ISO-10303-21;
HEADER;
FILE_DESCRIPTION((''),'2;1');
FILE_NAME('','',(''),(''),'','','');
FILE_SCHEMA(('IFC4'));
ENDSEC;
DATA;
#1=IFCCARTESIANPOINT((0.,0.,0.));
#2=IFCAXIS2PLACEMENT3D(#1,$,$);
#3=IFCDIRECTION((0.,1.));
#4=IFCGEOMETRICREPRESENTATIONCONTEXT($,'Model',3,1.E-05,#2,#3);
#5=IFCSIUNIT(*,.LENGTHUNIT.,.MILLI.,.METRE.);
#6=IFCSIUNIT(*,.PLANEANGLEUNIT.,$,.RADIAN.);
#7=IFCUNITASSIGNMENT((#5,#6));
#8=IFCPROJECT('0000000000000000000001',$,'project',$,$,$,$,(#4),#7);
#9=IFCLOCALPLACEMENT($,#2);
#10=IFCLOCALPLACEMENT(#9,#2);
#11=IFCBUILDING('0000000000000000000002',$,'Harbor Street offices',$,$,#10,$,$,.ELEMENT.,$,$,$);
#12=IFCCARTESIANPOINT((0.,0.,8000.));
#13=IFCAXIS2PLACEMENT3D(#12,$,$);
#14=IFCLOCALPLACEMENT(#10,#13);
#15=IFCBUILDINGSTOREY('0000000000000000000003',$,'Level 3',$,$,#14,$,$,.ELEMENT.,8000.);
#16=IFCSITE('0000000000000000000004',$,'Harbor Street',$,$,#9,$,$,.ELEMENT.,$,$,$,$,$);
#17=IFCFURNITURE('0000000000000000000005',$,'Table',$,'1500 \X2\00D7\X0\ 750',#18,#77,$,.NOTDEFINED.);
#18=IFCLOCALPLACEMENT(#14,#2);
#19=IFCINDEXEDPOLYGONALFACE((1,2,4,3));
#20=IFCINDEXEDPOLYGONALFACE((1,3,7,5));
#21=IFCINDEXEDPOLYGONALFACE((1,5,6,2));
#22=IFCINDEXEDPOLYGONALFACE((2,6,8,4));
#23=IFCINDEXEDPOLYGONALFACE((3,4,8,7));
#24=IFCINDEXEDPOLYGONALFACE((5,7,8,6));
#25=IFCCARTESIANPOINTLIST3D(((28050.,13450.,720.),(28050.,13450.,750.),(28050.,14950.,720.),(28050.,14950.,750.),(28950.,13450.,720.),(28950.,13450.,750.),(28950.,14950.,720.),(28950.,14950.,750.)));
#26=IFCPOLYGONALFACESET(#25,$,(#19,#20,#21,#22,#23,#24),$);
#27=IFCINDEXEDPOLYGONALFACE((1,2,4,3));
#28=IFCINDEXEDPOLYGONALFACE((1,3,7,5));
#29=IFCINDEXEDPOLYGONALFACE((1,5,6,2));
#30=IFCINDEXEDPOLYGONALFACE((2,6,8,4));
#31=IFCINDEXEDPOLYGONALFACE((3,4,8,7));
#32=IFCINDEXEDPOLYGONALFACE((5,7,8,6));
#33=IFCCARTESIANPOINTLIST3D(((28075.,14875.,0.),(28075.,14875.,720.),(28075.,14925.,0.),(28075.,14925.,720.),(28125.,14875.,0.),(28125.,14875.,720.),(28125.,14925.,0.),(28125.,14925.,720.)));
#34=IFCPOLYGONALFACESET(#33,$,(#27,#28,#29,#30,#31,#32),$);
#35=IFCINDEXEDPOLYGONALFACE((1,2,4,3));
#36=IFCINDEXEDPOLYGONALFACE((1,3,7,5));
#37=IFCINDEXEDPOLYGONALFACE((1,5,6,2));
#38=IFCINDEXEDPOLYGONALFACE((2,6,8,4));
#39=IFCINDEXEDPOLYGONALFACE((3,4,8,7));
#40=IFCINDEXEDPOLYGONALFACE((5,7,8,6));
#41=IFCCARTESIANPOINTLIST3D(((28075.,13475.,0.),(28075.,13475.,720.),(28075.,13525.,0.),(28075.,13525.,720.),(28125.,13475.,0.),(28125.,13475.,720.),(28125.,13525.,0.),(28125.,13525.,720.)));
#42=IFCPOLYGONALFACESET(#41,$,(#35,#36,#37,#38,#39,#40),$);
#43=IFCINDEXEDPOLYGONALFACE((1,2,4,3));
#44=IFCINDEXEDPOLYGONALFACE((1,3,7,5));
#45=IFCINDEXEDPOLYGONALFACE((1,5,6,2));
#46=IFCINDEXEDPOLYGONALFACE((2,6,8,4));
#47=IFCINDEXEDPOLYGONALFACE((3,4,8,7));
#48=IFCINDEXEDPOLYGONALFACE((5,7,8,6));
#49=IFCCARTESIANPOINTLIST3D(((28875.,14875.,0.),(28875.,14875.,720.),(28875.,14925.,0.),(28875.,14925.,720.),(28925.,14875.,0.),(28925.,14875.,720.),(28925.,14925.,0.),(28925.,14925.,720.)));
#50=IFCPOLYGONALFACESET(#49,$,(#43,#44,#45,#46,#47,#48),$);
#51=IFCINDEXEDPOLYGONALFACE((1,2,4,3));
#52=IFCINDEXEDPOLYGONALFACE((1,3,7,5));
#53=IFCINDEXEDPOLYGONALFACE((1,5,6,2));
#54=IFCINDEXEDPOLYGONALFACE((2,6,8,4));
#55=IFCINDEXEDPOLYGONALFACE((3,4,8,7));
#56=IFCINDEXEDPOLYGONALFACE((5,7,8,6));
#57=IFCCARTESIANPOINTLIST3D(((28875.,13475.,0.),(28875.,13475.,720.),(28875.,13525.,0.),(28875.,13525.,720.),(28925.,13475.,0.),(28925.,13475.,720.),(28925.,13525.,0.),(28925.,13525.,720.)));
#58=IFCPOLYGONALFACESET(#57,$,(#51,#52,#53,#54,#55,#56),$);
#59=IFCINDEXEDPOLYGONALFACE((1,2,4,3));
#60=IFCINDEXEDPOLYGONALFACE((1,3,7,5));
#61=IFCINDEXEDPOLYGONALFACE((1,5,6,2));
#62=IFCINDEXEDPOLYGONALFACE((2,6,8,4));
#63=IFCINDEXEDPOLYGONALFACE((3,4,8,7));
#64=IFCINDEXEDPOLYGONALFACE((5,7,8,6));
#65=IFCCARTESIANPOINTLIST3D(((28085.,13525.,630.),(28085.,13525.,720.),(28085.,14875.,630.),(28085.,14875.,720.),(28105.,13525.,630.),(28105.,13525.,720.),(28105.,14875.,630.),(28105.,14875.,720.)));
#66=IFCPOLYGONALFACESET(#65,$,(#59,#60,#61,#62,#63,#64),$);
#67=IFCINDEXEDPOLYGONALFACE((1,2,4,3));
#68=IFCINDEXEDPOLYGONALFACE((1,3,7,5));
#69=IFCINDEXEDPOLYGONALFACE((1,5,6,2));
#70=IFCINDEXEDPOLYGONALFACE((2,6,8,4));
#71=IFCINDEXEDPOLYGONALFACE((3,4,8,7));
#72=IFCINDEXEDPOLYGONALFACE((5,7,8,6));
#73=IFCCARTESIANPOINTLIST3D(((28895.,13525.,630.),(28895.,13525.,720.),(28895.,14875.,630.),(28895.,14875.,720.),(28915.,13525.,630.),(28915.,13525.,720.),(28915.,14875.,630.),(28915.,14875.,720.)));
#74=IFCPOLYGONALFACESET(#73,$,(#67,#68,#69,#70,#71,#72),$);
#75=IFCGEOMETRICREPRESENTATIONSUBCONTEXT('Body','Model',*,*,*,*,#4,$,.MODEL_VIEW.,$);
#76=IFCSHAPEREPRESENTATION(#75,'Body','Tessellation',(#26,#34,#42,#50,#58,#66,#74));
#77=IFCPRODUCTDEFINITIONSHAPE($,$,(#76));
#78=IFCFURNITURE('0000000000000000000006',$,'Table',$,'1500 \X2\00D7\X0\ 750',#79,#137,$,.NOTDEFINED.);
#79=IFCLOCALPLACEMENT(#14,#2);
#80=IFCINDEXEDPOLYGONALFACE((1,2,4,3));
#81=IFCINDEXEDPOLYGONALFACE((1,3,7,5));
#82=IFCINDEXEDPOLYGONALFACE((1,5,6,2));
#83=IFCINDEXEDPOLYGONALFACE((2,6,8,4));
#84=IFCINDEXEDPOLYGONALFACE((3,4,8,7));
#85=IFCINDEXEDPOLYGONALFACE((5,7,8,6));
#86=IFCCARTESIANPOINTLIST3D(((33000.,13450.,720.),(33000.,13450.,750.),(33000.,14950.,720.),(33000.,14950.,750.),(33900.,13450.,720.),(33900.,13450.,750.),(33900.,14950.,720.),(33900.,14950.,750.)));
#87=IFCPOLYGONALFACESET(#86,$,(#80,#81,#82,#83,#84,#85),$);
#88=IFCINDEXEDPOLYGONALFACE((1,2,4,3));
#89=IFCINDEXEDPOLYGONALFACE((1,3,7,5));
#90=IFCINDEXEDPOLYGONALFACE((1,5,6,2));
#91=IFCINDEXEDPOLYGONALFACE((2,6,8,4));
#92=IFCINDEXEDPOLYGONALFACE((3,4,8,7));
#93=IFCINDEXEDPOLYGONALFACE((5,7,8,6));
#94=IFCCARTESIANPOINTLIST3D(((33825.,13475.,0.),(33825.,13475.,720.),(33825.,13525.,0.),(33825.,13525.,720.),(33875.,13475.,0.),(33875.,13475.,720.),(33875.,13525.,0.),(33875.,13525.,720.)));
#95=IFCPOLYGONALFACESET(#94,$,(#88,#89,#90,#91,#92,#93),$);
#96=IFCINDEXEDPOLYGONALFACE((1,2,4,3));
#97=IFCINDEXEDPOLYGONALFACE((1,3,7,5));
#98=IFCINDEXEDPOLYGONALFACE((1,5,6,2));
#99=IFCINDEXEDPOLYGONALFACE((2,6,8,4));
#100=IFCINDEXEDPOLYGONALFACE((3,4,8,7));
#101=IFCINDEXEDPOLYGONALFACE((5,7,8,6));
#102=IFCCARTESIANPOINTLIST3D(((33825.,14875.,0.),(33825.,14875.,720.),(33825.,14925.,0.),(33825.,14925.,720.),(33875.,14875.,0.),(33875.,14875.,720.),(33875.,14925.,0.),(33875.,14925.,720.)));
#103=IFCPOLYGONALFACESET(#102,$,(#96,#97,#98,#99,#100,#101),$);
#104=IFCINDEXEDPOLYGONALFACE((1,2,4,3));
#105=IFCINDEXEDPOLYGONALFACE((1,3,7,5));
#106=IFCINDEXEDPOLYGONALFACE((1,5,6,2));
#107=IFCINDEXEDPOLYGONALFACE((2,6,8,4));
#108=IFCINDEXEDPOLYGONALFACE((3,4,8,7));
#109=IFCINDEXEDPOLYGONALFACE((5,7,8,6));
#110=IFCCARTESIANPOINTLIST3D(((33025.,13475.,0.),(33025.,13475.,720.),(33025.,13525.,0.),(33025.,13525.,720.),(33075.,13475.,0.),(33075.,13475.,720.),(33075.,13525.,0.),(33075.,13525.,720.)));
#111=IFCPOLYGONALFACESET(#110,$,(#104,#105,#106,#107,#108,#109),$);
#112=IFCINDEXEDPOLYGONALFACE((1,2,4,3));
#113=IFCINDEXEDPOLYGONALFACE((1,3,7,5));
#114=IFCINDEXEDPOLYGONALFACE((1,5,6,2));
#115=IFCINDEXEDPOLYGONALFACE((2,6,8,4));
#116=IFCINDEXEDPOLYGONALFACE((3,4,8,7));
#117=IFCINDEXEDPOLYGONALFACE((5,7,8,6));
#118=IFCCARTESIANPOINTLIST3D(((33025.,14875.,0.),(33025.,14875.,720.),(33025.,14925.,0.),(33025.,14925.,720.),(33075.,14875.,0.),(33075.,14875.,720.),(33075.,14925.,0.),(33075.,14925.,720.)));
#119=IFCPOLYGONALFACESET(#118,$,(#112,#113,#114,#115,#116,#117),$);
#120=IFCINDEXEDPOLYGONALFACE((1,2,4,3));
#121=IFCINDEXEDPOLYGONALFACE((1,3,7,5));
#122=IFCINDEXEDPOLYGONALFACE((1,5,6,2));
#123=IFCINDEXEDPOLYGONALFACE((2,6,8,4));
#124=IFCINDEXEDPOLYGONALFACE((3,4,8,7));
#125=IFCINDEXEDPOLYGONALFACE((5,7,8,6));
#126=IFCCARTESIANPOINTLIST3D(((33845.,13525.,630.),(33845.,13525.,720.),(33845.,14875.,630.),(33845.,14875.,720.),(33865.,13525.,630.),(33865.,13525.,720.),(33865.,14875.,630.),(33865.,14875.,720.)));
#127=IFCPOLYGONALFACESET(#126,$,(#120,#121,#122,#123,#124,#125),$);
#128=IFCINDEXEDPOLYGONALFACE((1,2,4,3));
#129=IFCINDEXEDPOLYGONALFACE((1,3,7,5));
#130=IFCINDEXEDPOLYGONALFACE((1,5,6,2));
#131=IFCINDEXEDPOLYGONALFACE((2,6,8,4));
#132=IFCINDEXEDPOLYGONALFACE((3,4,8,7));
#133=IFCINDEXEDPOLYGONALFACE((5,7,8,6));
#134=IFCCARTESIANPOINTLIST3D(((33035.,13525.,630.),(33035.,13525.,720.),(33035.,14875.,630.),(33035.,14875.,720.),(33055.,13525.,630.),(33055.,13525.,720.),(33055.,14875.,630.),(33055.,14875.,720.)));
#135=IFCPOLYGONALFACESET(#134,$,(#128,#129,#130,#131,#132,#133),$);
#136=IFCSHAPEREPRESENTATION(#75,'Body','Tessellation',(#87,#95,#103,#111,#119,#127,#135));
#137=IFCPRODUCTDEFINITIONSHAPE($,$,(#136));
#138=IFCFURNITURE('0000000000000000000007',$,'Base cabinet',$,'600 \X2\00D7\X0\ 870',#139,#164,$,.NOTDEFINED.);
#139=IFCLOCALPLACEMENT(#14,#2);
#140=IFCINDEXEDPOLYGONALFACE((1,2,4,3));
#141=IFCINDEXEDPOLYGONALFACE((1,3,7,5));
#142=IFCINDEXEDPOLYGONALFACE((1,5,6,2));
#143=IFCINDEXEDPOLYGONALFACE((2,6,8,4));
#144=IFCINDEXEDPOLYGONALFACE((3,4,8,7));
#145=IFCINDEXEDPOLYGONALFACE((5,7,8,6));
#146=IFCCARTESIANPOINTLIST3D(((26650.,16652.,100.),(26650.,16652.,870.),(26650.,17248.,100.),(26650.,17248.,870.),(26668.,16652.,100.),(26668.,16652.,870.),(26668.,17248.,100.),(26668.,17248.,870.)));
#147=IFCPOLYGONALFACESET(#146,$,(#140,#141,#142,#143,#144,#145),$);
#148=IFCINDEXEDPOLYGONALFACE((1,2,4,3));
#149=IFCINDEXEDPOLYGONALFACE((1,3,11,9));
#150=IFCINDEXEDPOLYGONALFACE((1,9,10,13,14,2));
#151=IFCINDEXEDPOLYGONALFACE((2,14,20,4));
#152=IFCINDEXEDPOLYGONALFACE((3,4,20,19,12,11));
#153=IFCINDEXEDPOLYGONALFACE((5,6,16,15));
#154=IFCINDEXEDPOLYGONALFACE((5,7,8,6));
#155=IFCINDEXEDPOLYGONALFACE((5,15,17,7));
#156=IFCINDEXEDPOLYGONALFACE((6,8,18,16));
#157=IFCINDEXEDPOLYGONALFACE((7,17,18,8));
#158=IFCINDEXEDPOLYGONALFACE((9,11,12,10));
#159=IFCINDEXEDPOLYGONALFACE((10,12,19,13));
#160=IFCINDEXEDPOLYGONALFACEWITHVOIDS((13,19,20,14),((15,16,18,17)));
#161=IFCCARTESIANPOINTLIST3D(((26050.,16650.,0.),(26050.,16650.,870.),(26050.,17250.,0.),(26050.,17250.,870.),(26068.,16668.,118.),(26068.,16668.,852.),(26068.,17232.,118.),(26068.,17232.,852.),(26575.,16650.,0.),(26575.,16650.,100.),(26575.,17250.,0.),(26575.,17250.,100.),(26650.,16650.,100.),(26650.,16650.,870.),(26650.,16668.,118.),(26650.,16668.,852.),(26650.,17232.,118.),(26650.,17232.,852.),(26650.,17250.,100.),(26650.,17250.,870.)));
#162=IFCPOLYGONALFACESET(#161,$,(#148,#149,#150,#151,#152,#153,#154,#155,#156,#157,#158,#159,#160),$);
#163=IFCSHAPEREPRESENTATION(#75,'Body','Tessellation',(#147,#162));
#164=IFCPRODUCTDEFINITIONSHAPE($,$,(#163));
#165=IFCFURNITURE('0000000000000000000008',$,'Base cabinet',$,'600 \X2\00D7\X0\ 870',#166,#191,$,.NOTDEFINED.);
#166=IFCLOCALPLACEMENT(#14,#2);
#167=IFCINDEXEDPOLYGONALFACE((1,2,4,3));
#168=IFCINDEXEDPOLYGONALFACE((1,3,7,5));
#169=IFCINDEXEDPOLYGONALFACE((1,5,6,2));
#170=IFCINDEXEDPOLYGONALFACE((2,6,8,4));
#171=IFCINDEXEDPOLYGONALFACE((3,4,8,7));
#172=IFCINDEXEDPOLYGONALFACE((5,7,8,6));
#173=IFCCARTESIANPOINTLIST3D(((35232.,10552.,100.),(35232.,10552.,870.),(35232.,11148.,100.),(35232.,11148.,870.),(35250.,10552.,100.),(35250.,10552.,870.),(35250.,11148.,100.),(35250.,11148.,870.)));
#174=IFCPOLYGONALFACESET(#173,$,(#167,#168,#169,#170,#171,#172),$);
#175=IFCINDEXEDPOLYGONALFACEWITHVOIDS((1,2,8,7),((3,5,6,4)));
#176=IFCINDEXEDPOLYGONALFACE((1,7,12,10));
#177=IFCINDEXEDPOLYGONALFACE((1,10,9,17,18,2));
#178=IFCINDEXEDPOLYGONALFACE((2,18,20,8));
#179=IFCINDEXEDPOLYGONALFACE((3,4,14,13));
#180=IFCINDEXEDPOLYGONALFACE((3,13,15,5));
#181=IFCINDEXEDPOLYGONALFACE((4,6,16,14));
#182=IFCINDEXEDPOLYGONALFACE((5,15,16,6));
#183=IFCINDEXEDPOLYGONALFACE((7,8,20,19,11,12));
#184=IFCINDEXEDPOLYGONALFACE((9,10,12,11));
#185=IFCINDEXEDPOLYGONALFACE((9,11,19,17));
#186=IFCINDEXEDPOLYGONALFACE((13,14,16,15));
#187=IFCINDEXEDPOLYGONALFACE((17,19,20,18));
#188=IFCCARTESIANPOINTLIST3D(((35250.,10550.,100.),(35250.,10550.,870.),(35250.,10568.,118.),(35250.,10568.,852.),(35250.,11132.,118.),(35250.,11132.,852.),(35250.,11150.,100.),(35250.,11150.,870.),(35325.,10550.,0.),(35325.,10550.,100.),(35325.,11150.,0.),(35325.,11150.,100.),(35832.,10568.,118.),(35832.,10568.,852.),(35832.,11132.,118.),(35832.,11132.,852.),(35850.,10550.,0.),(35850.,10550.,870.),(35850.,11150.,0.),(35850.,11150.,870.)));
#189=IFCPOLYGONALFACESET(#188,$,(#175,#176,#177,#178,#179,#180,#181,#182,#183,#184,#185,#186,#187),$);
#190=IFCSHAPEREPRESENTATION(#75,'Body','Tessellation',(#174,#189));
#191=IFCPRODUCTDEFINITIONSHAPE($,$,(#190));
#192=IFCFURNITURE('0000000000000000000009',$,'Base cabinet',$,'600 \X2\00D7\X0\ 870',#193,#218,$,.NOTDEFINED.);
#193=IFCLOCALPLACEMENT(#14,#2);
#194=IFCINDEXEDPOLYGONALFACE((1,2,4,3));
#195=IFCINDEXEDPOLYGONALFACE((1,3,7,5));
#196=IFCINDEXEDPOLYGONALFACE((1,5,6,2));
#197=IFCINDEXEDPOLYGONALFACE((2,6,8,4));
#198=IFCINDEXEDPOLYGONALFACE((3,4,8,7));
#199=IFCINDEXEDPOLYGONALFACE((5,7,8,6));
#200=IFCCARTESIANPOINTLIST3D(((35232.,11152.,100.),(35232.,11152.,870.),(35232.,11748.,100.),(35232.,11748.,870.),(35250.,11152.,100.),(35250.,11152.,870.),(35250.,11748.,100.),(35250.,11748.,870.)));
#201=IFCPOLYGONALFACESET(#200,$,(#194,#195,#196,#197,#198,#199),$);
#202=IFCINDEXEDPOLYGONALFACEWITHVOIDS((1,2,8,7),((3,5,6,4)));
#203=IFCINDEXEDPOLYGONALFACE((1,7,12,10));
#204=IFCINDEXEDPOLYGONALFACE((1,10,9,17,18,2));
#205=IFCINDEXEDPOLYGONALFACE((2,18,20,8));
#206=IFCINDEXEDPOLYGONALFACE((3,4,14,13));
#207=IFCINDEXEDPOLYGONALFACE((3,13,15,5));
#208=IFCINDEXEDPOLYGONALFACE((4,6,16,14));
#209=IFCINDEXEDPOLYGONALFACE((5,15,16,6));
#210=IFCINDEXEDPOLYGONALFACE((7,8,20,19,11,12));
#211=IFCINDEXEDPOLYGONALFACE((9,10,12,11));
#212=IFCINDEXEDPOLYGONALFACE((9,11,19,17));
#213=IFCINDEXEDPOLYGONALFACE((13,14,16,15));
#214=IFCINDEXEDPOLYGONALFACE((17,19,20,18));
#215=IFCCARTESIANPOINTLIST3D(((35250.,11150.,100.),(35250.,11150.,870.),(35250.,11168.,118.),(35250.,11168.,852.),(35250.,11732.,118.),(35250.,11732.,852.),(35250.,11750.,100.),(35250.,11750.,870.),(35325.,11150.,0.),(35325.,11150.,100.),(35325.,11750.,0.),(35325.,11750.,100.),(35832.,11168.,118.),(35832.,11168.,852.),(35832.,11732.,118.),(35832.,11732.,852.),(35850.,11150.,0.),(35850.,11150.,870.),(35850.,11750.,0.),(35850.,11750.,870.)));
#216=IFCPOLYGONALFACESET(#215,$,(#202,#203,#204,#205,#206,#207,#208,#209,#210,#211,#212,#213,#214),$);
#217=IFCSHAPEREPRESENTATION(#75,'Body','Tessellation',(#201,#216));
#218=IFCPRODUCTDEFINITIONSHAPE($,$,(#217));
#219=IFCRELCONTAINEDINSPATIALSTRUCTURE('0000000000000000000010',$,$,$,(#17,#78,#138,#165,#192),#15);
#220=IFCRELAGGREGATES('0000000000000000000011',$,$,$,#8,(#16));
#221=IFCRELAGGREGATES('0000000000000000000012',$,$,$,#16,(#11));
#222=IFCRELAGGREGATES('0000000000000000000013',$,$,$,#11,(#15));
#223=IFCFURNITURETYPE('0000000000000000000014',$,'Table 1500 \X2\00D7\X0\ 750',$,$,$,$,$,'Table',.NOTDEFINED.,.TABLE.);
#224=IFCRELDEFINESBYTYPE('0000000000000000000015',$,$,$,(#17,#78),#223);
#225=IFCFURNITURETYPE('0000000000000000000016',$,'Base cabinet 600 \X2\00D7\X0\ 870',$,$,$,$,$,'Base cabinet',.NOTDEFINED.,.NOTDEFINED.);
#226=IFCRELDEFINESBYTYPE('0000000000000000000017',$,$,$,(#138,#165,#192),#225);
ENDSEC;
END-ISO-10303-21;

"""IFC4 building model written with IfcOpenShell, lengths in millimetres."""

from ifc_helpers import new_model, entity, si_unit, direction, frame, origin, place, context, subcontext, project, spatial, polyline, outline, extrude, source, transform, mapped, type_object, type_shapes, element, save


model = new_model("IFC4")

# Units and contexts
model_context = context("Model", 3, precision=1e-05, world=origin(), true_north=direction((0.0, 1.0)))
body_context = subcontext(model_context, "Body", "Model", "MODEL_VIEW")
ifc_project = project(units=[si_unit("LENGTHUNIT", "METRE", prefix="MILLI"), si_unit("PLANEANGLEUNIT", "RADIAN")], contexts=[model_context])

# Site, building, storey
site_placement = place(None, origin())
site = spatial("IfcSite", under=ifc_project, at=site_placement, Name="Harbor Street", CompositionType="ELEMENT")
building_placement = place(site_placement, origin())
building = spatial("IfcBuilding", under=site, at=building_placement, Name="Harbor Street offices", CompositionType="ELEMENT")
storey_placement = place(building_placement, frame((0.0, 0.0, 8000.0)))
storey = spatial("IfcBuildingStorey", under=building, at=storey_placement, Name="Level 3", CompositionType="ELEMENT", Elevation=8000.0)

# Furniture
furniture_type_1 = type_object("IfcFurnitureType", Name="Table 1500 × 750", ElementType="Table", AssemblyPlace="NOTDEFINED", PredefinedType="TABLE")
shared_shape_1 = source(origin(), body_context, "Body", "SweptSolid", [
    extrude(outline(polyline([(-750.0, -450.0), (750.0, -450.0), (750.0, 450.0), (-750.0, 450.0), (-750.0, -450.0)])), frame((0.0, 0.0, 720.0)), (0.0, 0.0, 1.0), 30.0),
    extrude(outline(polyline([(-725.0, -425.0), (-675.0, -425.0), (-675.0, -375.0), (-725.0, -375.0), (-725.0, -425.0)])), origin(), (0.0, 0.0, 1.0), 720.0),
    extrude(outline(polyline([(675.0, -425.0), (725.0, -425.0), (725.0, -375.0), (675.0, -375.0), (675.0, -425.0)])), origin(), (0.0, 0.0, 1.0), 720.0),
    extrude(outline(polyline([(-725.0, 375.0), (-675.0, 375.0), (-675.0, 425.0), (-725.0, 425.0), (-725.0, 375.0)])), origin(), (0.0, 0.0, 1.0), 720.0),
    extrude(outline(polyline([(675.0, 375.0), (725.0, 375.0), (725.0, 425.0), (675.0, 425.0), (675.0, 375.0)])), origin(), (0.0, 0.0, 1.0), 720.0),
    extrude(outline(polyline([(-675.0, -415.0), (675.0, -415.0), (675.0, -395.0), (-675.0, -395.0), (-675.0, -415.0)])), frame((0.0, 0.0, 630.0)), (0.0, 0.0, 1.0), 90.0),
    extrude(outline(polyline([(-675.0, 395.0), (675.0, 395.0), (675.0, 415.0), (-675.0, 415.0), (-675.0, 395.0)])), frame((0.0, 0.0, 630.0)), (0.0, 0.0, 1.0), 90.0),
])
type_shapes(furniture_type_1, [shared_shape_1])
for number, where, z_axis, x_axis, name in (
    (1, (28500.0, 14200.0, 0.0), (0.0, 0.0, 1.0), (0.0, -1.0, 0.0), "Table"),
    (2, (33450.0, 14200.0, 0.0), (0.0, 0.0, 1.0), (0.0, 1.0, 0.0), "Table"),
):
    element("IfcFurniture", number, at=place(storey_placement, frame(where, z_axis=z_axis, x_axis=x_axis)), inside=storey, type_object=furniture_type_1, Name=name, ObjectType="1500 × 750", PredefinedType="NOTDEFINED", context=body_context, shape_type="MappedRepresentation", body=[
        mapped(shared_shape_1, transform((0.0, 0.0, 0.0))),
    ])
furniture_type_2 = type_object("IfcFurnitureType", Name="Base cabinet 600 × 870", ElementType="Base cabinet", AssemblyPlace="NOTDEFINED", PredefinedType="NOTDEFINED")
cartesian_point_1 = entity("IfcCartesianPoint", [-300.0, 0.0])
cartesian_point_2 = entity("IfcCartesianPoint", [-282.0, -1.0])
cartesian_point_3 = entity("IfcCartesianPoint", [-301.0, -1.0])
shared_shape_2 = source(origin(), body_context, "Body", "SolidModel", [
    extrude(outline(polyline([(-298.0, -18.0), (298.0, -18.0), (298.0, 0.0), (-298.0, 0.0), (-298.0, -18.0)])), frame((0.0, 0.0, 100.0)), (0.0, 0.0, 1.0), 770.0),
    entity("IfcCsgSolid", entity("IfcBooleanResult", "DIFFERENCE", entity("IfcBooleanResult", "DIFFERENCE", entity("IfcExtrudedAreaSolid", entity("IfcArbitraryClosedProfileDef", "AREA", None, entity("IfcPolyline", [cartesian_point_1, entity("IfcCartesianPoint", [300.0, 0.0]), entity("IfcCartesianPoint", [300.0, 600.0]), entity("IfcCartesianPoint", [-300.0, 600.0]), cartesian_point_1])), entity("IfcAxis2Placement3D", entity("IfcCartesianPoint", [0.0, 0.0, 0.0])), entity("IfcDirection", [0.0, 0.0, 1.0]), 870.0), entity("IfcExtrudedAreaSolid", entity("IfcArbitraryClosedProfileDef", "AREA", None, entity("IfcPolyline", [cartesian_point_2, entity("IfcCartesianPoint", [282.0, -1.0]), entity("IfcCartesianPoint", [282.0, 582.0]), entity("IfcCartesianPoint", [-282.0, 582.0]), cartesian_point_2])), entity("IfcAxis2Placement3D", entity("IfcCartesianPoint", [0.0, 0.0, 118.0])), entity("IfcDirection", [0.0, 0.0, 1.0]), 734.0)), entity("IfcExtrudedAreaSolid", entity("IfcArbitraryClosedProfileDef", "AREA", None, entity("IfcPolyline", [cartesian_point_3, entity("IfcCartesianPoint", [301.0, -1.0]), entity("IfcCartesianPoint", [301.0, 75.0]), entity("IfcCartesianPoint", [-301.0, 75.0]), cartesian_point_3])), entity("IfcAxis2Placement3D", entity("IfcCartesianPoint", [0.0, 0.0, -1.0])), entity("IfcDirection", [0.0, 0.0, 1.0]), 101.0))),
])
type_shapes(furniture_type_2, [shared_shape_2])
for number, where, z_axis, x_axis, name in (
    (3, (26650.0, 16950.0, 0.0), (0.0, 0.0, 1.0), (0.0, 1.0, 0.0), "Base cabinet"),
    (4, (35250.0, 10850.0, 0.0), (0.0, 0.0, 1.0), (0.0, -1.0, 0.0), "Base cabinet"),
    (5, (35250.0, 11450.0, 0.0), (0.0, 0.0, 1.0), (0.0, -1.0, 0.0), "Base cabinet"),
):
    element("IfcFurniture", number, at=place(storey_placement, frame(where, z_axis=z_axis, x_axis=x_axis)), inside=storey, type_object=furniture_type_2, Name=name, ObjectType="600 × 870", PredefinedType="NOTDEFINED", context=body_context, shape_type="MappedRepresentation", body=[
        mapped(shared_shape_2, transform((0.0, 0.0, 0.0))),
    ])

save(model, "model.ifc")
